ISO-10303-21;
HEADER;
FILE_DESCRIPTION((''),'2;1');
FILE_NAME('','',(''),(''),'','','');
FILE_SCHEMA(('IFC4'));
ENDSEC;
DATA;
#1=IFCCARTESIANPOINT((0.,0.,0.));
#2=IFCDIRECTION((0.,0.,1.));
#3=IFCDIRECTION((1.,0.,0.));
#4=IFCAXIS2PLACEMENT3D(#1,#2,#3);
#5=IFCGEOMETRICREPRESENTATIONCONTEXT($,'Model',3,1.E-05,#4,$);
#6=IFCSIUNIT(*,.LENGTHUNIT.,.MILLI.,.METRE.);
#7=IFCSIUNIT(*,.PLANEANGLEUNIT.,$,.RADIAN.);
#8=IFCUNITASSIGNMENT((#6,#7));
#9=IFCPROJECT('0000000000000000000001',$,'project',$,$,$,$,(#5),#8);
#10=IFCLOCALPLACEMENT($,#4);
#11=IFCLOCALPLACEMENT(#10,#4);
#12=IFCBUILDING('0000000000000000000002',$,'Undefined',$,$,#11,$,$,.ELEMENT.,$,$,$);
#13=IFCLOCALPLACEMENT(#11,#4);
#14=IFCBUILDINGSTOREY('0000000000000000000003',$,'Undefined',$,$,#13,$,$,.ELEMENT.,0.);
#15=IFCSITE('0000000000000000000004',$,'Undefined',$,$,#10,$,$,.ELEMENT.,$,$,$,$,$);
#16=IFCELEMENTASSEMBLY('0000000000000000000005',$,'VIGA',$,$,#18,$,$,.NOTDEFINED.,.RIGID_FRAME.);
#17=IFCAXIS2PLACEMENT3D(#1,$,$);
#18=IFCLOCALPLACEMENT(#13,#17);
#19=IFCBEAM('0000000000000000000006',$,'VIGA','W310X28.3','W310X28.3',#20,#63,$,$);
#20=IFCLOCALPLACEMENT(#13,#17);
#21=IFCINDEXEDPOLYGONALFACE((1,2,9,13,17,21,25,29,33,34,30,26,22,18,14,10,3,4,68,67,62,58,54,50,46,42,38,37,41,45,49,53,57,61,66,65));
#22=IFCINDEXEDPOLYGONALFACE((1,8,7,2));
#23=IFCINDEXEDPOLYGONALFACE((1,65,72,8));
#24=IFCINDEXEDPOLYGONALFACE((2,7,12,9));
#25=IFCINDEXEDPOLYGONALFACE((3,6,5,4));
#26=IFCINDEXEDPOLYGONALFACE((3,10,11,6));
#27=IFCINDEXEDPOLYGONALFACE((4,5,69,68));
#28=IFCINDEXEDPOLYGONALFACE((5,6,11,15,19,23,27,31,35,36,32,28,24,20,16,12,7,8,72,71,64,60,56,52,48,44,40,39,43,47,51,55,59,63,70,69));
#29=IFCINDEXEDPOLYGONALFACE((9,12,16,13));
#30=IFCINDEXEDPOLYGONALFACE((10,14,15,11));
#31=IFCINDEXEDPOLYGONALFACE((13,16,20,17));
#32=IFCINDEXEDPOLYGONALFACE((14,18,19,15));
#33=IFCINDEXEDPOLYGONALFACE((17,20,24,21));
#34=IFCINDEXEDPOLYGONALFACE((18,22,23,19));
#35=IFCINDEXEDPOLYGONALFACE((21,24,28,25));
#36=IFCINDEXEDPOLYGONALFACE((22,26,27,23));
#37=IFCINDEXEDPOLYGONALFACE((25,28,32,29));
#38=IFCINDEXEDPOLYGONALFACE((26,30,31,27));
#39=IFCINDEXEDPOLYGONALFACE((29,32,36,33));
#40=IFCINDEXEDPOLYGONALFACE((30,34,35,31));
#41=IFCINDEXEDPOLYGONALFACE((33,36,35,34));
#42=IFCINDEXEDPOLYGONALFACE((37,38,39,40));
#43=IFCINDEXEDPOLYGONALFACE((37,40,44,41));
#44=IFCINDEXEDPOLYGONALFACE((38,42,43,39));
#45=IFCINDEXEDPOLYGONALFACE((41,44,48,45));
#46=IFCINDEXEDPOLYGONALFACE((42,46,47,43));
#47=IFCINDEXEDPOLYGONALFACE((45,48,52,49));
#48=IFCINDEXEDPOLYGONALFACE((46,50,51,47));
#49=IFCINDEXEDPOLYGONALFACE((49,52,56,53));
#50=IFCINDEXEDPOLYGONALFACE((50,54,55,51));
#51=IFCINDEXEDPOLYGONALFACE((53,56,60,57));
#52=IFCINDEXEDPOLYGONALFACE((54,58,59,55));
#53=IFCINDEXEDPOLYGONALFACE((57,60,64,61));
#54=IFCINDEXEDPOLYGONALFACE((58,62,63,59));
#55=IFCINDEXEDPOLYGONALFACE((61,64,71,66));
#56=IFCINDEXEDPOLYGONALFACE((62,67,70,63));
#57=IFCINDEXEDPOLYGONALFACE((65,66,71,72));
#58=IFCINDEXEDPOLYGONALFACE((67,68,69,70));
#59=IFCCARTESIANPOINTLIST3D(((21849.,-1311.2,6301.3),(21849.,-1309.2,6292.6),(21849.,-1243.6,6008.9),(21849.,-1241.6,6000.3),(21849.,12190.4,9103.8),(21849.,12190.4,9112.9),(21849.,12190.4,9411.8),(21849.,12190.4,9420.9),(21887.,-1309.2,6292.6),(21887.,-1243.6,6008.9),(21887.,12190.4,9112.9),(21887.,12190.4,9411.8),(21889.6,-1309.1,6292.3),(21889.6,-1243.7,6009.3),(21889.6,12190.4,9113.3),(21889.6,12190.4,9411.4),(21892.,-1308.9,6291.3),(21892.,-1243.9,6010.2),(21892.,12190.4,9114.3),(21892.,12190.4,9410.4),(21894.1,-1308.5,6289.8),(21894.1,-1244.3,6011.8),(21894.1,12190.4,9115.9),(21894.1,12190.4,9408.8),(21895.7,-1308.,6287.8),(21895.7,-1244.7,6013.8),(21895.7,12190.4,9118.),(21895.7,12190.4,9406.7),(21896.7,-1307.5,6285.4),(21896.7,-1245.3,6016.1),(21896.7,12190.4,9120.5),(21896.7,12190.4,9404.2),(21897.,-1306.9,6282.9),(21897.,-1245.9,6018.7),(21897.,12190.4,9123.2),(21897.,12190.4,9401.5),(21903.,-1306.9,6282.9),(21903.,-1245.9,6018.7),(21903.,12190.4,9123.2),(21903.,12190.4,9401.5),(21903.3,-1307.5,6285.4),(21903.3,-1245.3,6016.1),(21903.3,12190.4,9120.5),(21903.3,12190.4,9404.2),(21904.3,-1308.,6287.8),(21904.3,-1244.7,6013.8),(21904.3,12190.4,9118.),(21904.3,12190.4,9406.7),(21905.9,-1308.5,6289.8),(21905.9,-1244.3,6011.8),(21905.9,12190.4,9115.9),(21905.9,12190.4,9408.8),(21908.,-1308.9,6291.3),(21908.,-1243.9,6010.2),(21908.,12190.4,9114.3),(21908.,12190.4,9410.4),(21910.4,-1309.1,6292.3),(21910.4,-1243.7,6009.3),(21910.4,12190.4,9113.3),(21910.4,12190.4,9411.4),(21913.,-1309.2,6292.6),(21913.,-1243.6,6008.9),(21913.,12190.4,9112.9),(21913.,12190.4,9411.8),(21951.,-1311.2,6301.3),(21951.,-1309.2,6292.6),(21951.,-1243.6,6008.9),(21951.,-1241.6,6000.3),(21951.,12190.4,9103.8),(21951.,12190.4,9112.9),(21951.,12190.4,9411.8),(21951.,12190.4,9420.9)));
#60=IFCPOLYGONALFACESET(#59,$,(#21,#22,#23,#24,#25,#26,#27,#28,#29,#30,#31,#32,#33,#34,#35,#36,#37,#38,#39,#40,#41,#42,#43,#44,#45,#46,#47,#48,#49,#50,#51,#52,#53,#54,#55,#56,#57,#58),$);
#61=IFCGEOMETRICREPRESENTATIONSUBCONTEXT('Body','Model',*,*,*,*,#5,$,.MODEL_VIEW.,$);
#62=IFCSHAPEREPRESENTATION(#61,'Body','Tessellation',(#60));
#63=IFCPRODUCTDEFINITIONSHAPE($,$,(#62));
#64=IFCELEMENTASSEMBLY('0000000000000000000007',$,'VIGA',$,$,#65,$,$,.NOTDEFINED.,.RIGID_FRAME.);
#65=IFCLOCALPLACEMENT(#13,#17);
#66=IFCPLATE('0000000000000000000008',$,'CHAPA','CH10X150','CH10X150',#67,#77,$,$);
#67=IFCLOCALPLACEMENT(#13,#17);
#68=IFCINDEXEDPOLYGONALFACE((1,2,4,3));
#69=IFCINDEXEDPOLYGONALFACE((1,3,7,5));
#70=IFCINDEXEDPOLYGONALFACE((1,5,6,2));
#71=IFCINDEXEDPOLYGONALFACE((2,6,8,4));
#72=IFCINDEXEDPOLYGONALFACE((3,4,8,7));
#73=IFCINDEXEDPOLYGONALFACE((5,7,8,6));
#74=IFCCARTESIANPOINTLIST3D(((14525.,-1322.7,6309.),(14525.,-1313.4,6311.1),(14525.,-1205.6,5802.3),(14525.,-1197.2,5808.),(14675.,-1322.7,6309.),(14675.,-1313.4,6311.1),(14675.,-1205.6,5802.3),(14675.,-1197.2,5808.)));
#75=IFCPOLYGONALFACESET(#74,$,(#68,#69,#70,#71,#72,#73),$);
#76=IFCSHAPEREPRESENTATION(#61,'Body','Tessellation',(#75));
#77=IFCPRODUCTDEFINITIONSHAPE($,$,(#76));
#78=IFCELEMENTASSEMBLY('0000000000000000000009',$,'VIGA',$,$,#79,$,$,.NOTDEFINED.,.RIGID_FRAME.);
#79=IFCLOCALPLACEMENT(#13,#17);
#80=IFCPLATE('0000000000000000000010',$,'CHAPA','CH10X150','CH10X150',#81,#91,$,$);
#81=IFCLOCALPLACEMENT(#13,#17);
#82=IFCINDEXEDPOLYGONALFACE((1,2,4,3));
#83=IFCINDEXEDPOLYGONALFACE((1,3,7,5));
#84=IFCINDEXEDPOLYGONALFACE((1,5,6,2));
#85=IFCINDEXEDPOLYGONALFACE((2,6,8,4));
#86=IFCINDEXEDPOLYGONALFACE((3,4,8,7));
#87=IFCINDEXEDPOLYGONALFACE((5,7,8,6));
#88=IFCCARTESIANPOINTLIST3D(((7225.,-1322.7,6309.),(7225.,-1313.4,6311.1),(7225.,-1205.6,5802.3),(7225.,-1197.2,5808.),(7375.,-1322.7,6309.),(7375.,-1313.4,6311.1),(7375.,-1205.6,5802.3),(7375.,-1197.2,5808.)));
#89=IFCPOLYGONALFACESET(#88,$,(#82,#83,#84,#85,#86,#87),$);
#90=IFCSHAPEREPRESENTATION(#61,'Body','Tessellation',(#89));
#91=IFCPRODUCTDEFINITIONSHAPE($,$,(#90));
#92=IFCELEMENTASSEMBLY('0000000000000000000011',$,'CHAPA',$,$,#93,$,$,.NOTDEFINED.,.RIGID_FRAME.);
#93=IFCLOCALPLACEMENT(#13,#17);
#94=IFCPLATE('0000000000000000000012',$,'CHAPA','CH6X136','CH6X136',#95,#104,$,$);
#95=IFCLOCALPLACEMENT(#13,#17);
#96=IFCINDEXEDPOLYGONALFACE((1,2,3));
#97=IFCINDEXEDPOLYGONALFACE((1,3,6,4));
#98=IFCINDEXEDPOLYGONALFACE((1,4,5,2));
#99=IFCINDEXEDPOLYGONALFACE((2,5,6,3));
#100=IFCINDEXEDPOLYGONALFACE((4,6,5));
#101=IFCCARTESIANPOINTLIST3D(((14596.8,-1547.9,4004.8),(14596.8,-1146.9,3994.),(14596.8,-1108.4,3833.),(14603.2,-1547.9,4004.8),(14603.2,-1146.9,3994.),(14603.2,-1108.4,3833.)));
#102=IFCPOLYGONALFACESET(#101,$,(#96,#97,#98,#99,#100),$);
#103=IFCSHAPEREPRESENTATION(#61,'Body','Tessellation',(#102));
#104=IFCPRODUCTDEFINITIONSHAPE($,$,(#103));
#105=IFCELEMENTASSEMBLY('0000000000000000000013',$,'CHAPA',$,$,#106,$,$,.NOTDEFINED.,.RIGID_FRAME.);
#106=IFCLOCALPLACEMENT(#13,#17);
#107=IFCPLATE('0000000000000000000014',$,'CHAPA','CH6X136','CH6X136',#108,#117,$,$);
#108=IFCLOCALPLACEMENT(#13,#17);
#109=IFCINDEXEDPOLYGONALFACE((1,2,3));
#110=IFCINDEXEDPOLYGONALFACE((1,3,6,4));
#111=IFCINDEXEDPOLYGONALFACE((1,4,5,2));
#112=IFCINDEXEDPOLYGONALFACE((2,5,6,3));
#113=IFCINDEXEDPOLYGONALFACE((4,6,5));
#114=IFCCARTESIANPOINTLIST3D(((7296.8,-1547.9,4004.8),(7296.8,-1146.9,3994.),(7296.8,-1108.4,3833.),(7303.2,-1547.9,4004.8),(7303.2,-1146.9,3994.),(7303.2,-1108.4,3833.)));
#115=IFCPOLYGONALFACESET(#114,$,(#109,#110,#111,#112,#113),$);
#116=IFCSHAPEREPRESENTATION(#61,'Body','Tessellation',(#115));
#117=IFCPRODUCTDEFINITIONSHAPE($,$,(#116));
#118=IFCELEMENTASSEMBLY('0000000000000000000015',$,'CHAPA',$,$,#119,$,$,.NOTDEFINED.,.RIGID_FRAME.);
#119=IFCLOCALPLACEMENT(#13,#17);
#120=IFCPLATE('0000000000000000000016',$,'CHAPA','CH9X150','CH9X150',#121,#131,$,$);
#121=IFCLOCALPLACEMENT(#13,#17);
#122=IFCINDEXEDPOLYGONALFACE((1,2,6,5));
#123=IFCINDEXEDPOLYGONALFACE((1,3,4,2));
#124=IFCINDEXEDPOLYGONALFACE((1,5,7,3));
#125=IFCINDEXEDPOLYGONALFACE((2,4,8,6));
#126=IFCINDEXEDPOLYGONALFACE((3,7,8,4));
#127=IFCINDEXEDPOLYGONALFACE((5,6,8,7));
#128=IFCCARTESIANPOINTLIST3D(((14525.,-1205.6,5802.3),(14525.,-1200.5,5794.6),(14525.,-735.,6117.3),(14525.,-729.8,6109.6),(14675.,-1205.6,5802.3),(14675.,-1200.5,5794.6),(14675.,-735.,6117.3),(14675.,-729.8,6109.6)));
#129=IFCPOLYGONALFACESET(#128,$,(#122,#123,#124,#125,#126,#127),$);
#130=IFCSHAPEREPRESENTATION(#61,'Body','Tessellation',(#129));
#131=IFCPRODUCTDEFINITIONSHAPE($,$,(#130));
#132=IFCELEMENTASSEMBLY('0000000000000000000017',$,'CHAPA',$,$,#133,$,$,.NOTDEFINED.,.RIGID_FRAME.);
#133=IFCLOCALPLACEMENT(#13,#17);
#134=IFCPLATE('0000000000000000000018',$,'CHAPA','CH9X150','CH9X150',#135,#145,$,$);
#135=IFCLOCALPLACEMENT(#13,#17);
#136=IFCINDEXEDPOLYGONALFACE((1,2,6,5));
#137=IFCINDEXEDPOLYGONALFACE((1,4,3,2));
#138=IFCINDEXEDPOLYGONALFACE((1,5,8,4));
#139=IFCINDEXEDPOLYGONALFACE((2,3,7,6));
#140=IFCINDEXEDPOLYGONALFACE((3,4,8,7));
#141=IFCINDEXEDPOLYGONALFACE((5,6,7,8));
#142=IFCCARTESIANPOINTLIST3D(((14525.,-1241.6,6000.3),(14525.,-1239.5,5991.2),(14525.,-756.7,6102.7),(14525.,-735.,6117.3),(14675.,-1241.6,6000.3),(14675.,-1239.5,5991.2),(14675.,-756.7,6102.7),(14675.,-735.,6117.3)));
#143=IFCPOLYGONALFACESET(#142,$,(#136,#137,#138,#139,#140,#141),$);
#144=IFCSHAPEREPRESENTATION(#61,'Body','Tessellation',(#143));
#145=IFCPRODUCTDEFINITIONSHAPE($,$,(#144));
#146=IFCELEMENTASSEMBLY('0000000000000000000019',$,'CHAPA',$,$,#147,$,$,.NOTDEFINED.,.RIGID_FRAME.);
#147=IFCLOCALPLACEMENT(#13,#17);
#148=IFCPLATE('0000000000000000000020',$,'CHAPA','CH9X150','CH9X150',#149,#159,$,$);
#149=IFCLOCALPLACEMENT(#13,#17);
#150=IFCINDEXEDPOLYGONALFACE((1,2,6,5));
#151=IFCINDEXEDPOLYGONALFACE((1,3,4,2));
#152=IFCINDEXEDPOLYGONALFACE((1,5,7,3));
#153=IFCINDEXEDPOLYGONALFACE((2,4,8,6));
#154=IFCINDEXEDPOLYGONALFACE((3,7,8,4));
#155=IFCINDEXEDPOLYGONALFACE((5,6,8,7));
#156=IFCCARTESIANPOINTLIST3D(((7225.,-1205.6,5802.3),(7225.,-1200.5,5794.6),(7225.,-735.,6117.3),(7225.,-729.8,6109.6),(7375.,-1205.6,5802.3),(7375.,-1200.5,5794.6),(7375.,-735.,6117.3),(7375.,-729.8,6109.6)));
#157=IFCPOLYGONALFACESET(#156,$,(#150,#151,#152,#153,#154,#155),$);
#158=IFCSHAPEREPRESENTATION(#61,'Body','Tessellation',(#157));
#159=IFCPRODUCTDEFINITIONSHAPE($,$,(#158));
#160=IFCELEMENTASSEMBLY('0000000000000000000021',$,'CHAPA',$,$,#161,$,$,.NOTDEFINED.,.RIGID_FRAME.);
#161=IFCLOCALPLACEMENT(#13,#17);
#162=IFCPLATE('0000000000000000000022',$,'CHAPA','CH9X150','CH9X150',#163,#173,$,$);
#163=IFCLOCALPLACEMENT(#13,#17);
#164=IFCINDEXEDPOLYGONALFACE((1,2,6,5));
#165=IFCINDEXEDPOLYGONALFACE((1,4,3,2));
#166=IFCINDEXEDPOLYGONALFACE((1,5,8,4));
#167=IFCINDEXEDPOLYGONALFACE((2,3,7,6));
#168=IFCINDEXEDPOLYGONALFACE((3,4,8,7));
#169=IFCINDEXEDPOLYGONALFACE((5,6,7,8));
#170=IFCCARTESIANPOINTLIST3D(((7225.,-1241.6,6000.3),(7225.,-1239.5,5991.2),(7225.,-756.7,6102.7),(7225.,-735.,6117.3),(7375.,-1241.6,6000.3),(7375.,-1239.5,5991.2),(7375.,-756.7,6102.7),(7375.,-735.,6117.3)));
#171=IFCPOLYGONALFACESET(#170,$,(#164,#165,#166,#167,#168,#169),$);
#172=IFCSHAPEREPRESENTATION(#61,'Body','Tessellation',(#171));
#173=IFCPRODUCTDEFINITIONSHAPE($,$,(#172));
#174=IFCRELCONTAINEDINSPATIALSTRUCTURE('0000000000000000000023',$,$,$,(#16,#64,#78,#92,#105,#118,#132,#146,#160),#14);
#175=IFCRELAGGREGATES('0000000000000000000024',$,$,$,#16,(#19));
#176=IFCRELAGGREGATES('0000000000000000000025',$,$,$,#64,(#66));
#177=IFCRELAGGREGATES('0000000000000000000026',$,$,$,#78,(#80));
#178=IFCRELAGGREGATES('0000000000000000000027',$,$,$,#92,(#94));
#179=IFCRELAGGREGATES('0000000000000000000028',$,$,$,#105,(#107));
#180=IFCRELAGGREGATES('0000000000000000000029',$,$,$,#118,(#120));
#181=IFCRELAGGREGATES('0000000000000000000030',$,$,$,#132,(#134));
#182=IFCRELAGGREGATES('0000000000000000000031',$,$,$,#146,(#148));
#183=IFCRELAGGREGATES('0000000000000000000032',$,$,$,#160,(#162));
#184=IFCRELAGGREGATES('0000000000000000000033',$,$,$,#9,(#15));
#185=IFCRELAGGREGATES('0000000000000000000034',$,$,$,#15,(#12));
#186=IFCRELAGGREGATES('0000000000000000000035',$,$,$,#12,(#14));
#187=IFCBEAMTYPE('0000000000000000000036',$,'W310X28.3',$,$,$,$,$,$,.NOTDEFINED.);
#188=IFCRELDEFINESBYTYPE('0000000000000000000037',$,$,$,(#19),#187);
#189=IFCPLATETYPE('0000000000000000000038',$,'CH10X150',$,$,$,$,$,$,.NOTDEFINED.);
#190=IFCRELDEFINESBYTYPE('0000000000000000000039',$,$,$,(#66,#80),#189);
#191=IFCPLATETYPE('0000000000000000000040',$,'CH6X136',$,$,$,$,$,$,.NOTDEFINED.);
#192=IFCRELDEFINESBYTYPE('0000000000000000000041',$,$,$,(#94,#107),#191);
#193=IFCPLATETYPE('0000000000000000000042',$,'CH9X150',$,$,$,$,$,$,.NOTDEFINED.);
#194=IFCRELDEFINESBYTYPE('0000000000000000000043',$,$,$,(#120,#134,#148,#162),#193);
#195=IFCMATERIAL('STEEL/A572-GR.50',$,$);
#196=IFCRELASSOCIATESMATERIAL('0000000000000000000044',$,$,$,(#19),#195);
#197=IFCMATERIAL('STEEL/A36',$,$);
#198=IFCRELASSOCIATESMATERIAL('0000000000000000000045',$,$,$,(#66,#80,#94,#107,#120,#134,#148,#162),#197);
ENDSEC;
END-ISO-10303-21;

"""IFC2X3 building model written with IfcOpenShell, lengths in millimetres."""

from ifc_helpers import new_model, si_unit, frame, origin_with_axes, origin_2d_with_axis, place, context, subcontext, project, spatial, polyline, i_section, outline, extrude, clip, halfspace, material, type_object, element, aggregate, save


model = new_model("IFC2X3")

# Units and contexts
model_context = context("Model", 3, precision=1e-05, world=origin_with_axes())
body_context = subcontext(model_context, "Body", "Model", "MODEL_VIEW")
ifc_project = project(units=[si_unit("LENGTHUNIT", "METRE", prefix="MILLI"), si_unit("PLANEANGLEUNIT", "RADIAN")], contexts=[model_context])

# Site, building, storey
site_placement = place(None, origin_with_axes())
site = spatial("IfcSite", under=ifc_project, at=site_placement, Name="Undefined", CompositionType="ELEMENT")
building_placement = place(site_placement, origin_with_axes())
building = spatial("IfcBuilding", under=site, at=building_placement, Name="Undefined", CompositionType="ELEMENT")
storey_placement = place(building_placement, origin_with_axes())
storey = spatial("IfcBuildingStorey", under=building, at=storey_placement, Name="Undefined", CompositionType="ELEMENT", Elevation=0.0)

# Element assemblies, beam
assembly_1_placement = place(storey_placement, origin_with_axes())
assembly_1 = element("IfcElementAssembly", 1, at=assembly_1_placement, inside=storey, Name="VIGA", AssemblyPlace="NOTDEFINED", PredefinedType="RIGID_FRAME")
ifc_material_1 = material(Name="STEEL/A572-GR.50")
beam_type_1 = type_object("IfcBeamType", Name="W310X28.3", PredefinedType="NOTDEFINED")
beam_1_placement = place(assembly_1_placement, frame((21900.0, -1276.4, 6150.8), z_axis=(0.0, 0.225124, -0.97433), x_axis=(0.0, 0.97433, 0.225124)))
beam_1 = element("IfcBeam", 2, at=beam_1_placement, type_object=beam_type_1, material=ifc_material_1, Name="VIGA", Description="W310X28.3", ObjectType="W310X28.3", context=body_context, shape_type="Clipping", body=[
    clip(extrude(i_section(OverallWidth=102.0, OverallDepth=309.0, WebThickness=6.0, FlangeThickness=8.9, FilletRadius=10.0, at=origin_2d_with_axis()), frame((13995.7, 0.0, 0.0), z_axis=(-1.0, 0.0, 0.0), x_axis=(0.0, -1.0, 0.0)), (0.0, 0.0, 1.0), 13995.7), halfspace(frame((13857.8, 0.0, -156.7), z_axis=(0.97433, 0.0, 0.225124), x_axis=(-0.225124, 0.0, 0.97433)), False)),
])
aggregate(assembly_1, [beam_1])
assembly_2_placement = place(storey_placement, origin_with_axes())
assembly_2 = element("IfcElementAssembly", 3, at=assembly_2_placement, inside=storey, Name="VIGA", AssemblyPlace="NOTDEFINED", PredefinedType="RIGID_FRAME")

# Plate
ifc_material_2 = material(Name="STEEL/A36")
plate_type_1 = type_object("IfcPlateType", Name="CH10X150", PredefinedType="NOTDEFINED")
plate_1_placement = place(assembly_2_placement, frame((14675.0, -1318.1, 6310.1), z_axis=(0.0, 0.97433, 0.225124), x_axis=(0.0, 0.225124, -0.97433)))
plate_1 = element("IfcPlate", 4, at=plate_1_placement, type_object=plate_type_1, material=ifc_material_2, Name="CHAPA", Description="CH10X150", ObjectType="CH10X150", context=body_context, shape_type="Clipping", body=[
    clip(extrude(outline(polyline([(0.0, 0.0), (520.0, 0.0), (520.0, 150.0), (0.0, 150.0), (0.0, 0.0)])), frame((0.0, 0.0, -4.8), z_axis=(0.0, 0.0, 1.0), x_axis=(1.0, 0.0, 0.0)), (0.0, 0.0, 1.0), 9.5), halfspace(frame((516.4, -500.0, 4.8), z_axis=(0.934951, 0.0, 0.354778), x_axis=(0.0, 1.0, 0.0)), False)),
])
aggregate(assembly_2, [plate_1])

# Element assemblies, plates
assembly_3_placement = place(storey_placement, origin_with_axes())
assembly_3 = element("IfcElementAssembly", 5, at=assembly_3_placement, inside=storey, Name="VIGA", AssemblyPlace="NOTDEFINED", PredefinedType="RIGID_FRAME")
plate_2_placement = place(assembly_3_placement, frame((7375.0, -1318.1, 6310.1), z_axis=(0.0, 0.97433, 0.225124), x_axis=(0.0, 0.225124, -0.97433)))
plate_2 = element("IfcPlate", 6, at=plate_2_placement, type_object=plate_type_1, material=ifc_material_2, Name="CHAPA", Description="CH10X150", ObjectType="CH10X150", context=body_context, shape_type="Clipping", body=[
    clip(extrude(outline(polyline([(0.0, 0.0), (520.0, 0.0), (520.0, 150.0), (0.0, 150.0), (0.0, 0.0)])), frame((0.0, 0.0, -4.8), z_axis=(0.0, 0.0, 1.0), x_axis=(1.0, 0.0, 0.0)), (0.0, 0.0, 1.0), 9.5), halfspace(frame((516.4, -500.0, 4.8), z_axis=(0.934951, 0.0, 0.354778), x_axis=(0.0, 1.0, 0.0)), False)),
])
aggregate(assembly_3, [plate_2])
assembly_4_placement = place(storey_placement, origin_with_axes())
assembly_4 = element("IfcElementAssembly", 7, at=assembly_4_placement, inside=storey, Name="CHAPA", AssemblyPlace="NOTDEFINED", PredefinedType="RIGID_FRAME")
plate_type_2 = type_object("IfcPlateType", Name="CH6X136", PredefinedType="NOTDEFINED")
plate_3_placement = place(assembly_4_placement, frame((14600.0, -1146.9, 3994.0), z_axis=(1.0, 0.0, 0.0), x_axis=(0.0, -0.999636, 0.026972)))
plate_3 = element("IfcPlate", 8, at=plate_3_placement, type_object=plate_type_2, material=ifc_material_2, Name="CHAPA", Description="CH6X136", ObjectType="CH6X136", context=body_context, shape_type="SweptSolid", body=[
    extrude(outline(polyline([(0.0, 0.0), (401.1, 0.0), (-42.8, 159.9), (0.0, 0.0)])), frame((0.0, 0.0, -3.1), z_axis=(0.0, 0.0, 1.0), x_axis=(1.0, 0.0, 0.0)), (0.0, 0.0, 1.0), 6.3),
])
aggregate(assembly_4, [plate_3])
assembly_5_placement = place(storey_placement, origin_with_axes())
assembly_5 = element("IfcElementAssembly", 9, at=assembly_5_placement, inside=storey, Name="CHAPA", AssemblyPlace="NOTDEFINED", PredefinedType="RIGID_FRAME")
plate_4_placement = place(assembly_5_placement, frame((7300.0, -1146.9, 3994.0), z_axis=(1.0, 0.0, 0.0), x_axis=(0.0, -0.999636, 0.026972)))
plate_4 = element("IfcPlate", 10, at=plate_4_placement, type_object=plate_type_2, material=ifc_material_2, Name="CHAPA", Description="CH6X136", ObjectType="CH6X136", context=body_context, shape_type="SweptSolid", body=[
    extrude(outline(polyline([(0.0, 0.0), (401.1, 0.0), (-42.8, 159.9), (0.0, 0.0)])), frame((0.0, 0.0, -3.1), z_axis=(0.0, 0.0, 1.0), x_axis=(1.0, 0.0, 0.0)), (0.0, 0.0, 1.0), 6.3),
])
aggregate(assembly_5, [plate_4])
assembly_6_placement = place(storey_placement, origin_with_axes())
assembly_6 = element("IfcElementAssembly", 11, at=assembly_6_placement, inside=storey, Name="CHAPA", AssemblyPlace="NOTDEFINED", PredefinedType="RIGID_FRAME")
plate_type_3 = type_object("IfcPlateType", Name="CH9X150", PredefinedType="NOTDEFINED")
plate_5_placement = place(assembly_6_placement, frame((14675.0, -732.4, 6113.5), z_axis=(0.0, -0.55615, 0.831082), x_axis=(-1.0, 0.0, 0.0)))
plate_5 = element("IfcPlate", 12, at=plate_5_placement, type_object=plate_type_3, material=ifc_material_2, Name="CHAPA", Description="CH9X150", ObjectType="CH9X150", context=body_context, shape_type="SweptSolid", body=[
    extrude(outline(polyline([(0.0, 0.0), (150.0, 0.0), (150.0, 566.3), (0.0, 566.3), (0.0, 0.0)])), frame((0.0, 0.0, -4.7), z_axis=(0.0, 0.0, 1.0), x_axis=(1.0, 0.0, 0.0)), (0.0, 0.0, 1.0), 9.3),
])
aggregate(assembly_6, [plate_5])
assembly_7_placement = place(storey_placement, origin_with_axes())
assembly_7 = element("IfcElementAssembly", 13, at=assembly_7_placement, inside=storey, Name="CHAPA", AssemblyPlace="NOTDEFINED", PredefinedType="RIGID_FRAME")
plate_6_placement = place(assembly_7_placement, frame((14675.0, -1240.6, 5995.7), z_axis=(0.0, -0.225124, 0.97433), x_axis=(0.0, 0.97433, 0.225124)))
plate_6 = element("IfcPlate", 14, at=plate_6_placement, type_object=plate_type_3, material=ifc_material_2, Name="CHAPA", Description="CH9X150", ObjectType="CH9X150", context=body_context, shape_type="Clipping", body=[
    clip(extrude(outline(polyline([(0.0, 0.0), (520.0, 0.0), (520.0, 150.0), (0.0, 150.0), (0.0, 0.0)])), frame((0.0, 0.0, -4.7), z_axis=(0.0, 0.0, 1.0), x_axis=(1.0, 0.0, 0.0)), (0.0, 0.0, 1.0), 9.3), halfspace(frame((520.0, -500.0, 4.7), z_axis=(0.354778, 0.0, -0.934951), x_axis=(0.0, 1.0, 0.0)), False)),
])
aggregate(assembly_7, [plate_6])
assembly_8_placement = place(storey_placement, origin_with_axes())
assembly_8 = element("IfcElementAssembly", 15, at=assembly_8_placement, inside=storey, Name="CHAPA", AssemblyPlace="NOTDEFINED", PredefinedType="RIGID_FRAME")
plate_7_placement = place(assembly_8_placement, frame((7375.0, -732.4, 6113.5), z_axis=(0.0, -0.55615, 0.831082), x_axis=(-1.0, 0.0, 0.0)))
plate_7 = element("IfcPlate", 16, at=plate_7_placement, type_object=plate_type_3, material=ifc_material_2, Name="CHAPA", Description="CH9X150", ObjectType="CH9X150", context=body_context, shape_type="SweptSolid", body=[
    extrude(outline(polyline([(0.0, 0.0), (150.0, 0.0), (150.0, 566.3), (0.0, 566.3), (0.0, 0.0)])), frame((0.0, 0.0, -4.7), z_axis=(0.0, 0.0, 1.0), x_axis=(1.0, 0.0, 0.0)), (0.0, 0.0, 1.0), 9.3),
])
aggregate(assembly_8, [plate_7])
assembly_9_placement = place(storey_placement, origin_with_axes())
assembly_9 = element("IfcElementAssembly", 17, at=assembly_9_placement, inside=storey, Name="CHAPA", AssemblyPlace="NOTDEFINED", PredefinedType="RIGID_FRAME")
plate_8_placement = place(assembly_9_placement, frame((7375.0, -1240.6, 5995.7), z_axis=(0.0, -0.225124, 0.97433), x_axis=(0.0, 0.97433, 0.225124)))
plate_8 = element("IfcPlate", 18, at=plate_8_placement, type_object=plate_type_3, material=ifc_material_2, Name="CHAPA", Description="CH9X150", ObjectType="CH9X150", context=body_context, shape_type="Clipping", body=[
    clip(extrude(outline(polyline([(0.0, 0.0), (520.0, 0.0), (520.0, 150.0), (0.0, 150.0), (0.0, 0.0)])), frame((0.0, 0.0, -4.7), z_axis=(0.0, 0.0, 1.0), x_axis=(1.0, 0.0, 0.0)), (0.0, 0.0, 1.0), 9.3), halfspace(frame((520.0, -500.0, 4.7), z_axis=(0.354778, 0.0, -0.934951), x_axis=(0.0, 1.0, 0.0)), False)),
])
aggregate(assembly_9, [plate_8])

save(model, "model.ifc")
